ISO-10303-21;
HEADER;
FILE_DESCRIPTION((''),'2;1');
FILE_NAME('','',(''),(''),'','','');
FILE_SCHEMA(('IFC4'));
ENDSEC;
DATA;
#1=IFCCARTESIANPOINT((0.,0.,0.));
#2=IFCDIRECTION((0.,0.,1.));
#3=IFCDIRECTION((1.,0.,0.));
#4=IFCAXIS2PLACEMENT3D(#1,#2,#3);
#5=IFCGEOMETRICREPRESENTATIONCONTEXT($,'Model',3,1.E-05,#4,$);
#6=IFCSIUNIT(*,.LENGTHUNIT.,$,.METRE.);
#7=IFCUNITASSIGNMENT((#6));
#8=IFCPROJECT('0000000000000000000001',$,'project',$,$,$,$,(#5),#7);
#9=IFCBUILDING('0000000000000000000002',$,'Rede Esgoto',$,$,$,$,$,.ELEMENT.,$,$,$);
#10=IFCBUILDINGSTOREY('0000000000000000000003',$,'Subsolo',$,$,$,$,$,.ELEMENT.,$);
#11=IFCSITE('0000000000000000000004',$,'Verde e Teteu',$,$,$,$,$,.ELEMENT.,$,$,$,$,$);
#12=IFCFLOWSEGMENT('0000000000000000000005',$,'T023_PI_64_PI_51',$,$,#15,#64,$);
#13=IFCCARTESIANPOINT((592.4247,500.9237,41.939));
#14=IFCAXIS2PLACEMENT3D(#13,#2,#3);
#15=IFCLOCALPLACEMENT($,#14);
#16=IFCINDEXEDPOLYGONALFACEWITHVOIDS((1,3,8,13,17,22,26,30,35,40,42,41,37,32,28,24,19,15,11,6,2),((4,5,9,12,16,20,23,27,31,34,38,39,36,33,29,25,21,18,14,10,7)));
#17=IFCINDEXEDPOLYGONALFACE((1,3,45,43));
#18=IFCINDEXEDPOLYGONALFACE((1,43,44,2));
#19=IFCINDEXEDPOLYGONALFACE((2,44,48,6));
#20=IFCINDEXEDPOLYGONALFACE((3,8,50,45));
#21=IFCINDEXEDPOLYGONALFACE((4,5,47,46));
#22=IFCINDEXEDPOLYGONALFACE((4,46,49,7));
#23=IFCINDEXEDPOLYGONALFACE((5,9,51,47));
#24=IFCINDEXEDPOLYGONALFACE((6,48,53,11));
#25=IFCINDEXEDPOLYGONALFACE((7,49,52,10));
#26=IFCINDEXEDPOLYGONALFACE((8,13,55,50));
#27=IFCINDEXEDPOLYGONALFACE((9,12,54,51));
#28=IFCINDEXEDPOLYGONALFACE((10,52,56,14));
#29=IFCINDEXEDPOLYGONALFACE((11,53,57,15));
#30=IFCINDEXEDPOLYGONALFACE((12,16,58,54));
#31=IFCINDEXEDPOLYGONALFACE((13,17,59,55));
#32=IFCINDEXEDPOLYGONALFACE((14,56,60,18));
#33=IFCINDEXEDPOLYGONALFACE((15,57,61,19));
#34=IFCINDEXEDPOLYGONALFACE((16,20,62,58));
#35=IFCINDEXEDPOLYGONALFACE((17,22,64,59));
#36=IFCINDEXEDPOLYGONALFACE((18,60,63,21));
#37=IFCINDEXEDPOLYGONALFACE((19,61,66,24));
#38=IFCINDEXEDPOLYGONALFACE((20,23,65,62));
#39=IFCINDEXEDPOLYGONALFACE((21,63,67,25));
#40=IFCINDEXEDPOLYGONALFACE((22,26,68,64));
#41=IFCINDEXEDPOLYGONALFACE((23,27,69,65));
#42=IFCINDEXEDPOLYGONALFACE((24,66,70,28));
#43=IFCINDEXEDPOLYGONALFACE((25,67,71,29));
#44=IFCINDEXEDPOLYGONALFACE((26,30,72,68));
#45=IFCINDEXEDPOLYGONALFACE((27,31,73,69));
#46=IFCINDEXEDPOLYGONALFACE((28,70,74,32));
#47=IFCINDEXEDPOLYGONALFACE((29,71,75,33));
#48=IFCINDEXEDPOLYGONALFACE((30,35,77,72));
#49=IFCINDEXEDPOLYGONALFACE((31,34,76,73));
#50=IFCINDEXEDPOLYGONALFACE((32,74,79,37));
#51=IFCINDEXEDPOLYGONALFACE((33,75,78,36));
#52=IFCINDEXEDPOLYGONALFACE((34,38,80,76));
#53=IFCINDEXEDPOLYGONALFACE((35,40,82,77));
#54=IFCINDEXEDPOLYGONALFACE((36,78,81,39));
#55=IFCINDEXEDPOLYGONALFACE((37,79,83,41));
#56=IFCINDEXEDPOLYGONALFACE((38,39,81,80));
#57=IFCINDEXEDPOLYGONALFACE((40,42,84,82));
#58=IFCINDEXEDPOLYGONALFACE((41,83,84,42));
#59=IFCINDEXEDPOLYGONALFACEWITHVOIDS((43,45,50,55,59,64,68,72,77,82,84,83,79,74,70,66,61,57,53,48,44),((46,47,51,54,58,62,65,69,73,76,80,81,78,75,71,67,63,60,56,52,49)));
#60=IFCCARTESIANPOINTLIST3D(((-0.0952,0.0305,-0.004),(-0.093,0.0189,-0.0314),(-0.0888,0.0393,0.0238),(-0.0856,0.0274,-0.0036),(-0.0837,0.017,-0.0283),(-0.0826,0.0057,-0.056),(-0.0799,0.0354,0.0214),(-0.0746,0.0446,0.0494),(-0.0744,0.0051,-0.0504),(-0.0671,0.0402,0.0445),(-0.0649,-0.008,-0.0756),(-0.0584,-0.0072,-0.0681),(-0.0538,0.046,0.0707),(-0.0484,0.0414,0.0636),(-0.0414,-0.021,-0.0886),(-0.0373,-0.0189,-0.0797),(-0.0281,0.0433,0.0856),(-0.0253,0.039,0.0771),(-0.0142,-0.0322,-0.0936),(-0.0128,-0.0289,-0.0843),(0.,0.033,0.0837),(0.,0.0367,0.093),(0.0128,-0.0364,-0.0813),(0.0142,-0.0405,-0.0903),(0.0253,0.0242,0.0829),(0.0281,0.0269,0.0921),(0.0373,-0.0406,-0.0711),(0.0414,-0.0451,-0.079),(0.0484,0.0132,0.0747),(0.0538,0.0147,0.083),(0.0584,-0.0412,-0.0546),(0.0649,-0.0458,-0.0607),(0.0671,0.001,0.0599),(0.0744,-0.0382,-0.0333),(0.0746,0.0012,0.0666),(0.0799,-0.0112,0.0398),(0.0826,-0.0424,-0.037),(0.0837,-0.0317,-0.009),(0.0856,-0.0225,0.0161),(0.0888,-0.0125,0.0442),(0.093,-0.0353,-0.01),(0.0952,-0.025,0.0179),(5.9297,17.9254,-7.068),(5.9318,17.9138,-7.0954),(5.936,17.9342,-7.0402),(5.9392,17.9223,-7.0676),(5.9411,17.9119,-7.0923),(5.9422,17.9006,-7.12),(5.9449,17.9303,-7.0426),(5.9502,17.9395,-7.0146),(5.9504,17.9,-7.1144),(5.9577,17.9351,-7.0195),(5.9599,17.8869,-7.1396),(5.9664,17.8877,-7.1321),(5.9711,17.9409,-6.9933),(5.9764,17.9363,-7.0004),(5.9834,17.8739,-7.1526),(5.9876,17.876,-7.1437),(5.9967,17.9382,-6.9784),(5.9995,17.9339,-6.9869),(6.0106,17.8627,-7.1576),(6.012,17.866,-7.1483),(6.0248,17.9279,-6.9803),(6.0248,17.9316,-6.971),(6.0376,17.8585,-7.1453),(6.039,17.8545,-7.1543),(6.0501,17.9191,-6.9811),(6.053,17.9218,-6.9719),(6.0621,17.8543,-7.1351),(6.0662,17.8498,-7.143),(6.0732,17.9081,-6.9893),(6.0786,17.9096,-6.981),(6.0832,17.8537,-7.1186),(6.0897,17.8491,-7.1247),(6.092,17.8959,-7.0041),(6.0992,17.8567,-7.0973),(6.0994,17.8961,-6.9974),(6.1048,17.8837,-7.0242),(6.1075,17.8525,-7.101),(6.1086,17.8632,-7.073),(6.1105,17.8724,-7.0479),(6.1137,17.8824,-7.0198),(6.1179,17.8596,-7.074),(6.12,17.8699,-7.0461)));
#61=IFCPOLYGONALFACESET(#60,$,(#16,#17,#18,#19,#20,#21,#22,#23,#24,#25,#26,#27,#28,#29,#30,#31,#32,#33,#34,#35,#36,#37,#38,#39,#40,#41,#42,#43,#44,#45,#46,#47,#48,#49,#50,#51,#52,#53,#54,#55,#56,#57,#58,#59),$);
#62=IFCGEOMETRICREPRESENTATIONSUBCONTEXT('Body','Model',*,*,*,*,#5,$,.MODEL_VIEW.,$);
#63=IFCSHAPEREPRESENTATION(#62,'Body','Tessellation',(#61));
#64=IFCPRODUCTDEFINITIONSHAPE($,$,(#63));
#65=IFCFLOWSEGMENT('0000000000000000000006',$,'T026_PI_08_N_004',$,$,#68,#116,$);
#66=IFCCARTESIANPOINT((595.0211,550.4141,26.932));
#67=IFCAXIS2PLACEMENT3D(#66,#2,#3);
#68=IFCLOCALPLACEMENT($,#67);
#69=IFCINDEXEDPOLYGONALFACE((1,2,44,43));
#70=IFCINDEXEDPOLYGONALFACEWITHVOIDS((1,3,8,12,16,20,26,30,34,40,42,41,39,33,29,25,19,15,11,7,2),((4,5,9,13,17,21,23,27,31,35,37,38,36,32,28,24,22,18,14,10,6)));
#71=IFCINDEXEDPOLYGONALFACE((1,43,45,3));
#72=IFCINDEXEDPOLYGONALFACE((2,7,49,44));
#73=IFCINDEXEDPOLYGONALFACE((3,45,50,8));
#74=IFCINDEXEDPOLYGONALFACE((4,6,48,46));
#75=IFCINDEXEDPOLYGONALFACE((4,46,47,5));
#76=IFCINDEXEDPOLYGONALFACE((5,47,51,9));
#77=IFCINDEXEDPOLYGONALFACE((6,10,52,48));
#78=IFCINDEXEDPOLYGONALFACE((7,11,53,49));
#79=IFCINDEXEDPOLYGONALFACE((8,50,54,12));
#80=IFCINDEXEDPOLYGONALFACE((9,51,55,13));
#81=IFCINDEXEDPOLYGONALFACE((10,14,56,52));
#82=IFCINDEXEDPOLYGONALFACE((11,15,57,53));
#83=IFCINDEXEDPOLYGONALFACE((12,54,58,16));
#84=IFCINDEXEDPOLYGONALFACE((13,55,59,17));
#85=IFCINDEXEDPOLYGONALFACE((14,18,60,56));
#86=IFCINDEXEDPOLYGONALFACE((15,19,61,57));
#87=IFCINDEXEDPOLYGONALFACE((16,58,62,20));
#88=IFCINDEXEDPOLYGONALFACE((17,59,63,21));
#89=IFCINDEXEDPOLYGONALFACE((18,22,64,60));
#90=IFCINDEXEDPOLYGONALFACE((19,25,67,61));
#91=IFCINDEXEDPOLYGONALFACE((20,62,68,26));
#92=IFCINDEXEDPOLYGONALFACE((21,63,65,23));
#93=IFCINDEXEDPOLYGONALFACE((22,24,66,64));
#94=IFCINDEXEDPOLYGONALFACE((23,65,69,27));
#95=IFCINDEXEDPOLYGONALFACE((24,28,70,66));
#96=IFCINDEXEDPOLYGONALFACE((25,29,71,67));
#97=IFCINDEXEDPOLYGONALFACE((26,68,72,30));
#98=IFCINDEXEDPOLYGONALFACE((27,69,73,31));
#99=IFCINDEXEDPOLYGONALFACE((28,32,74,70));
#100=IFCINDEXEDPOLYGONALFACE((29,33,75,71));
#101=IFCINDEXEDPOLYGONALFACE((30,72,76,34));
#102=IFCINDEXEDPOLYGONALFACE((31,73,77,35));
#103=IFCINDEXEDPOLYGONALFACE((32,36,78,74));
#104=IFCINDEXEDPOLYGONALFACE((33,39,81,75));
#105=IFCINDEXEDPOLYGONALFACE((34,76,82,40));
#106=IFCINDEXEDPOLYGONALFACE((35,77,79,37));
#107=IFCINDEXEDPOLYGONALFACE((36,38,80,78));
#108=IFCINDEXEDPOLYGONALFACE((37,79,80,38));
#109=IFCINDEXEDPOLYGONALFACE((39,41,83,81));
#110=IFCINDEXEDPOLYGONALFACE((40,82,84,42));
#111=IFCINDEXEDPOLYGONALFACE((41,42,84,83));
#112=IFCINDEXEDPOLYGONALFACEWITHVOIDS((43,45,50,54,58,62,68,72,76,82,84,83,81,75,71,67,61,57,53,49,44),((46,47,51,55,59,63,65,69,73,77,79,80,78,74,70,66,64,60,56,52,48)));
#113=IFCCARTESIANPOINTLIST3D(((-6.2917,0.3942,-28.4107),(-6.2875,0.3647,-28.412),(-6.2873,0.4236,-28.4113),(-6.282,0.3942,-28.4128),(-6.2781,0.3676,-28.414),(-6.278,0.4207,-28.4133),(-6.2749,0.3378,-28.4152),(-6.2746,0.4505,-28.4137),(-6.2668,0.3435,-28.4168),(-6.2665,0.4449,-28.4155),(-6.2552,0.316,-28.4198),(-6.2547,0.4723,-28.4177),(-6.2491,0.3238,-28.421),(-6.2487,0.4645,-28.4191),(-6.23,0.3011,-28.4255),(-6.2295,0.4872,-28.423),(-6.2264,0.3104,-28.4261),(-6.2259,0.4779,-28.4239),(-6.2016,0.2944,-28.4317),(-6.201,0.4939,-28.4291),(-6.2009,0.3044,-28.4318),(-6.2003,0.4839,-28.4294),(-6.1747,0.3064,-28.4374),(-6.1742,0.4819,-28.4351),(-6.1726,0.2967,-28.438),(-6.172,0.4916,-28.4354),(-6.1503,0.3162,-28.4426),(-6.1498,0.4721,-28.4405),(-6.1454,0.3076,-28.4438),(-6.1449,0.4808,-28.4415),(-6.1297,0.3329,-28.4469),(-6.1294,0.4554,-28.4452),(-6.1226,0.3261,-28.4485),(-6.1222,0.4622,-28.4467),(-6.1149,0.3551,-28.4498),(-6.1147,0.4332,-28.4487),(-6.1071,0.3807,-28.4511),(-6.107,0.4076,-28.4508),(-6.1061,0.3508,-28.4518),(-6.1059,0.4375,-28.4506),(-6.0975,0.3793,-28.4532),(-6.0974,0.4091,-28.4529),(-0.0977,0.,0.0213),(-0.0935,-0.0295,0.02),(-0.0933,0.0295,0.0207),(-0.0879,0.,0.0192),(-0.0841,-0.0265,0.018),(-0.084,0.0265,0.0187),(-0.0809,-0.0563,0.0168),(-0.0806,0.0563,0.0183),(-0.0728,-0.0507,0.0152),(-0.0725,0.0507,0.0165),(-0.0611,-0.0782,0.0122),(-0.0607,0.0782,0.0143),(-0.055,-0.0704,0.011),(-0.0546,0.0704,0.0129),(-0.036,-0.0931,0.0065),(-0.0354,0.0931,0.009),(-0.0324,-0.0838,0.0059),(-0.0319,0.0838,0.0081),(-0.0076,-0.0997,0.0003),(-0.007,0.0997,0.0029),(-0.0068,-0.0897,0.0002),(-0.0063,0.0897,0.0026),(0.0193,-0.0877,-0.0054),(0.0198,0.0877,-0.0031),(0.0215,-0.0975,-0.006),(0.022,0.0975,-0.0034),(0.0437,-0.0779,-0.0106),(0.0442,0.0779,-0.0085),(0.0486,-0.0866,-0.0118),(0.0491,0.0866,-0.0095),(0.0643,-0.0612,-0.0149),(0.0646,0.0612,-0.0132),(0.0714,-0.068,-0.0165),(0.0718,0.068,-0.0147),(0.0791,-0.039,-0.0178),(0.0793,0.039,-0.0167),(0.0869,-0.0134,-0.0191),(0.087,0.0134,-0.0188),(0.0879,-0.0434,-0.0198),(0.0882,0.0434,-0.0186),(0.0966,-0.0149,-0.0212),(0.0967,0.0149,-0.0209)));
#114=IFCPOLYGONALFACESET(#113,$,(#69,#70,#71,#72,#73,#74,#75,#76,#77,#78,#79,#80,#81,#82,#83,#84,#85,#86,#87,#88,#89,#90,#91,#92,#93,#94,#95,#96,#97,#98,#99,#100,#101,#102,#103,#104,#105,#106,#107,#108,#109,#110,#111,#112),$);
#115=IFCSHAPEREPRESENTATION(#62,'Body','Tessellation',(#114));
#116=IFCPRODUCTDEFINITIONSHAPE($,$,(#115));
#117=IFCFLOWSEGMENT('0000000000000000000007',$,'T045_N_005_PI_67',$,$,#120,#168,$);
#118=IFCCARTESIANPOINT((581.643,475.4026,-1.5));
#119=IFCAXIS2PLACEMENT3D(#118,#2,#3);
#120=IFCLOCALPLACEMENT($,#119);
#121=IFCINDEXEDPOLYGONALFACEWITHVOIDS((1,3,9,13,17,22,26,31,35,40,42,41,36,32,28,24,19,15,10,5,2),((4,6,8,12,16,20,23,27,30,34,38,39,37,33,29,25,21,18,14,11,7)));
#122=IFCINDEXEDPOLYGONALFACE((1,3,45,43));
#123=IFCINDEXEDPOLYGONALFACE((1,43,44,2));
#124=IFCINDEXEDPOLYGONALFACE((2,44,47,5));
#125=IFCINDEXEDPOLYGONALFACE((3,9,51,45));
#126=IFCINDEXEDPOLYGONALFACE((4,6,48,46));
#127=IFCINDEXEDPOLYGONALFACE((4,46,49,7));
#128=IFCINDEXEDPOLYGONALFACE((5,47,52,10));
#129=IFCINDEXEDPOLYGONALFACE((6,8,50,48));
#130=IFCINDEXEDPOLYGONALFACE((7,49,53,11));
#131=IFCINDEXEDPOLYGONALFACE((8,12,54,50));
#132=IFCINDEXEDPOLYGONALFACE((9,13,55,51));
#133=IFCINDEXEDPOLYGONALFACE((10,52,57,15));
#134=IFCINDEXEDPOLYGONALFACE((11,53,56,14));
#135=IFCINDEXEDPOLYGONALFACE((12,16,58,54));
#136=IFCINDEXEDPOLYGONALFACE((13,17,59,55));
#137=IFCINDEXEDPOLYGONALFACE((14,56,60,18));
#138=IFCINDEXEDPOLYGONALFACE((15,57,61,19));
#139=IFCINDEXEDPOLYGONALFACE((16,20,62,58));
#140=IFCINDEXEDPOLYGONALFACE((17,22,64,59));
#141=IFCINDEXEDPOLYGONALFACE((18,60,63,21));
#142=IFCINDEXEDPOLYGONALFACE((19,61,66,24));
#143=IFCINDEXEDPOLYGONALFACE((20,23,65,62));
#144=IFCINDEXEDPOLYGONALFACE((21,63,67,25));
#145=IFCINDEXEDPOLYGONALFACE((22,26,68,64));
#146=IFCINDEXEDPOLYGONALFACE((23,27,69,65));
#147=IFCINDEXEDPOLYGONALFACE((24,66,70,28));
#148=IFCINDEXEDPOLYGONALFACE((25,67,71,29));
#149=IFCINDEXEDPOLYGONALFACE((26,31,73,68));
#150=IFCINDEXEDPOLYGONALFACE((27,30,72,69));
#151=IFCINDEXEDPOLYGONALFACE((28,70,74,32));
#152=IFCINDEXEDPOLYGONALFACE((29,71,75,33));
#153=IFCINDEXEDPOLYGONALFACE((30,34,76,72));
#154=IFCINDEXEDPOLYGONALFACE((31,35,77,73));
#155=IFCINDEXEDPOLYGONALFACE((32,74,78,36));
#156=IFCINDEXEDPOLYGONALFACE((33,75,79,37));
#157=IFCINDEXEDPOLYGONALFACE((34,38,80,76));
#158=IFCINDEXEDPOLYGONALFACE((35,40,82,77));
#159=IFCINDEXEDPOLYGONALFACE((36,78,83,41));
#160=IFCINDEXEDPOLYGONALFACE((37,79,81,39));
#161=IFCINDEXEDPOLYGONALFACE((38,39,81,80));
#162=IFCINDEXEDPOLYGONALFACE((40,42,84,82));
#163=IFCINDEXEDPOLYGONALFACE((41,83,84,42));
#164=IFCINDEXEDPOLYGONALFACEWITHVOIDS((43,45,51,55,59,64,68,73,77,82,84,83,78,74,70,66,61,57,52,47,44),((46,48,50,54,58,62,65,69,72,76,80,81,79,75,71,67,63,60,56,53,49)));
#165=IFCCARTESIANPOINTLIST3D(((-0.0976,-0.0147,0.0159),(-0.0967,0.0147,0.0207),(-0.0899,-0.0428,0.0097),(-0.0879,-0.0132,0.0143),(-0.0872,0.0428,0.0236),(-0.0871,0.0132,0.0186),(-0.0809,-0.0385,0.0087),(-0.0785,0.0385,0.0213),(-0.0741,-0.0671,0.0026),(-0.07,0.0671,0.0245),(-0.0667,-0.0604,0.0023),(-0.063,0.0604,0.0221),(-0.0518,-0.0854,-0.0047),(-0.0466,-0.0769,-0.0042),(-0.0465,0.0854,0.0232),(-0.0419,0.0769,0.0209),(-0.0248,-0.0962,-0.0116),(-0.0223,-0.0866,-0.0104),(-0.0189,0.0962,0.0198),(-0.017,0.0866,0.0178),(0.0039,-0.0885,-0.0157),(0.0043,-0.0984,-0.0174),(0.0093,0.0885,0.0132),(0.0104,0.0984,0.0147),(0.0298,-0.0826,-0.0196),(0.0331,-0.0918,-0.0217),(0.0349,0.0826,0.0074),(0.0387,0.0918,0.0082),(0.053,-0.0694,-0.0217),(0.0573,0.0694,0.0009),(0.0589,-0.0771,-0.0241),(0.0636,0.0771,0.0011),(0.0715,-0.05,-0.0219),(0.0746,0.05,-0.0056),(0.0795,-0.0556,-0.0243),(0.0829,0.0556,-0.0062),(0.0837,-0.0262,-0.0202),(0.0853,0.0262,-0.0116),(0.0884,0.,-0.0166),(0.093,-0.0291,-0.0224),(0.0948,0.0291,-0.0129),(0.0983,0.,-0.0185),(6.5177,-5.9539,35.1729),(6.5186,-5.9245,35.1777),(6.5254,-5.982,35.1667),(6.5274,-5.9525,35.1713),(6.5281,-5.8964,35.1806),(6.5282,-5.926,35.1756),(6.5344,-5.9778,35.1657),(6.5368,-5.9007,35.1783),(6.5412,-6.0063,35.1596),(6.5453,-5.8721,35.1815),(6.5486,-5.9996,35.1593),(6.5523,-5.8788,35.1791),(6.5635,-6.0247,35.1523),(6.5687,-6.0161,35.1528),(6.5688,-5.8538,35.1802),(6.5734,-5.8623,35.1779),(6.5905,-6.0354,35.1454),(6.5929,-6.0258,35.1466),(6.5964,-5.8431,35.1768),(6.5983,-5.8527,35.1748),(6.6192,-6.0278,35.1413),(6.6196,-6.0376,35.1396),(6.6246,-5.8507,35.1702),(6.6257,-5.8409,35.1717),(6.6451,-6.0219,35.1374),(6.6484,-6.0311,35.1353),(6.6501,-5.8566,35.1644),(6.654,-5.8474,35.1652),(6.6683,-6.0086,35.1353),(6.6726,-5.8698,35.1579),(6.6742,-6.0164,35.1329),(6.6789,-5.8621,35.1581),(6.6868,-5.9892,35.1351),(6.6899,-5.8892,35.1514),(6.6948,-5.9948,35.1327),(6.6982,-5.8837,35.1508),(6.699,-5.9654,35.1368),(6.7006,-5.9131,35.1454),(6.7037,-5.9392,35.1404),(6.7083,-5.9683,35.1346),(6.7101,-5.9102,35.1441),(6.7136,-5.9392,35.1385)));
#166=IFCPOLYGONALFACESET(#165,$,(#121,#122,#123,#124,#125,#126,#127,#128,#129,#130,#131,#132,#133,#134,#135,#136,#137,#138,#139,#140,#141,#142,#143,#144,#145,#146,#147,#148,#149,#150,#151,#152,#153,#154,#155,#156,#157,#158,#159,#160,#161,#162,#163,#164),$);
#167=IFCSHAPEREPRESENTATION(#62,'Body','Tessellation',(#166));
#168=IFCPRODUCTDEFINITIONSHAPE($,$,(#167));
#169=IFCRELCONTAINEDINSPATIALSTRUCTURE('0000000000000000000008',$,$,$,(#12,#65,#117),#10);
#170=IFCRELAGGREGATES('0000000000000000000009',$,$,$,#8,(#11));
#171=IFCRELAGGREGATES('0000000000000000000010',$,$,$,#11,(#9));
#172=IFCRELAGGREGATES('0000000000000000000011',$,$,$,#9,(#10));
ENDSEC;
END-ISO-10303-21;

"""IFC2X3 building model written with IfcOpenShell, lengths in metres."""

from ifc_helpers import new_model, entity, si_unit, frame, origin_with_axes, place, context, subcontext, project, spatial, element, save


model = new_model("IFC2X3")

# Units and contexts
model_context = context("Model", 3, precision=1e-05, world=origin_with_axes())
body_context = subcontext(model_context, "Body", "Model", "MODEL_VIEW")
ifc_project = project(units=[si_unit("LENGTHUNIT", "METRE")], contexts=[model_context])

# Site, building, storey
site = spatial("IfcSite", under=ifc_project, Name="Verde e Teteu", CompositionType="ELEMENT")
building = spatial("IfcBuilding", under=site, Name="Rede Esgoto", CompositionType="ELEMENT")
storey = spatial("IfcBuildingStorey", under=building, Name="Subsolo", CompositionType="ELEMENT")

# Flow segments
flow_segment_1_placement = place(None, frame((592.4247, 500.9237, 41.939), z_axis=(0.0, 0.0, 1.0), x_axis=(1.0, 0.0, 0.0)))
element("IfcFlowSegment", 1, at=flow_segment_1_placement, inside=storey, Name="T023_PI_64_PI_51", context=body_context, shape_type="SweptSolid", body=[
    entity("IfcSweptDiskSolid", entity("IfcPolyline", [entity("IfcCartesianPoint", [0.0, 0.0, 0.0]), entity("IfcCartesianPoint", [6.0248, 17.8949, -7.064])]), 0.1, 0.09),
])
flow_segment_2_placement = place(None, frame((595.0211, 550.4141, 26.932), z_axis=(0.0, 0.0, 1.0), x_axis=(1.0, 0.0, 0.0)))
element("IfcFlowSegment", 2, at=flow_segment_2_placement, inside=storey, Name="T026_PI_08_N_004", context=body_context, shape_type="SweptSolid", body=[
    entity("IfcSweptDiskSolid", entity("IfcPolyline", [entity("IfcCartesianPoint", [0.0, 0.0, 0.0]), entity("IfcCartesianPoint", [-6.194, 0.3942, -28.432])]), 0.1, 0.09),
])
flow_segment_3_placement = place(None, frame((581.643, 475.4026, -1.5), z_axis=(0.0, 0.0, 1.0), x_axis=(1.0, 0.0, 0.0)))
element("IfcFlowSegment", 3, at=flow_segment_3_placement, inside=storey, Name="T045_N_005_PI_67", context=body_context, shape_type="SweptSolid", body=[
    entity("IfcSweptDiskSolid", entity("IfcPolyline", [entity("IfcCartesianPoint", [0.0, 0.0, 0.0]), entity("IfcCartesianPoint", [6.6153, -5.9392, 35.157])]), 0.1, 0.09),
])

save(model, "model.ifc")
